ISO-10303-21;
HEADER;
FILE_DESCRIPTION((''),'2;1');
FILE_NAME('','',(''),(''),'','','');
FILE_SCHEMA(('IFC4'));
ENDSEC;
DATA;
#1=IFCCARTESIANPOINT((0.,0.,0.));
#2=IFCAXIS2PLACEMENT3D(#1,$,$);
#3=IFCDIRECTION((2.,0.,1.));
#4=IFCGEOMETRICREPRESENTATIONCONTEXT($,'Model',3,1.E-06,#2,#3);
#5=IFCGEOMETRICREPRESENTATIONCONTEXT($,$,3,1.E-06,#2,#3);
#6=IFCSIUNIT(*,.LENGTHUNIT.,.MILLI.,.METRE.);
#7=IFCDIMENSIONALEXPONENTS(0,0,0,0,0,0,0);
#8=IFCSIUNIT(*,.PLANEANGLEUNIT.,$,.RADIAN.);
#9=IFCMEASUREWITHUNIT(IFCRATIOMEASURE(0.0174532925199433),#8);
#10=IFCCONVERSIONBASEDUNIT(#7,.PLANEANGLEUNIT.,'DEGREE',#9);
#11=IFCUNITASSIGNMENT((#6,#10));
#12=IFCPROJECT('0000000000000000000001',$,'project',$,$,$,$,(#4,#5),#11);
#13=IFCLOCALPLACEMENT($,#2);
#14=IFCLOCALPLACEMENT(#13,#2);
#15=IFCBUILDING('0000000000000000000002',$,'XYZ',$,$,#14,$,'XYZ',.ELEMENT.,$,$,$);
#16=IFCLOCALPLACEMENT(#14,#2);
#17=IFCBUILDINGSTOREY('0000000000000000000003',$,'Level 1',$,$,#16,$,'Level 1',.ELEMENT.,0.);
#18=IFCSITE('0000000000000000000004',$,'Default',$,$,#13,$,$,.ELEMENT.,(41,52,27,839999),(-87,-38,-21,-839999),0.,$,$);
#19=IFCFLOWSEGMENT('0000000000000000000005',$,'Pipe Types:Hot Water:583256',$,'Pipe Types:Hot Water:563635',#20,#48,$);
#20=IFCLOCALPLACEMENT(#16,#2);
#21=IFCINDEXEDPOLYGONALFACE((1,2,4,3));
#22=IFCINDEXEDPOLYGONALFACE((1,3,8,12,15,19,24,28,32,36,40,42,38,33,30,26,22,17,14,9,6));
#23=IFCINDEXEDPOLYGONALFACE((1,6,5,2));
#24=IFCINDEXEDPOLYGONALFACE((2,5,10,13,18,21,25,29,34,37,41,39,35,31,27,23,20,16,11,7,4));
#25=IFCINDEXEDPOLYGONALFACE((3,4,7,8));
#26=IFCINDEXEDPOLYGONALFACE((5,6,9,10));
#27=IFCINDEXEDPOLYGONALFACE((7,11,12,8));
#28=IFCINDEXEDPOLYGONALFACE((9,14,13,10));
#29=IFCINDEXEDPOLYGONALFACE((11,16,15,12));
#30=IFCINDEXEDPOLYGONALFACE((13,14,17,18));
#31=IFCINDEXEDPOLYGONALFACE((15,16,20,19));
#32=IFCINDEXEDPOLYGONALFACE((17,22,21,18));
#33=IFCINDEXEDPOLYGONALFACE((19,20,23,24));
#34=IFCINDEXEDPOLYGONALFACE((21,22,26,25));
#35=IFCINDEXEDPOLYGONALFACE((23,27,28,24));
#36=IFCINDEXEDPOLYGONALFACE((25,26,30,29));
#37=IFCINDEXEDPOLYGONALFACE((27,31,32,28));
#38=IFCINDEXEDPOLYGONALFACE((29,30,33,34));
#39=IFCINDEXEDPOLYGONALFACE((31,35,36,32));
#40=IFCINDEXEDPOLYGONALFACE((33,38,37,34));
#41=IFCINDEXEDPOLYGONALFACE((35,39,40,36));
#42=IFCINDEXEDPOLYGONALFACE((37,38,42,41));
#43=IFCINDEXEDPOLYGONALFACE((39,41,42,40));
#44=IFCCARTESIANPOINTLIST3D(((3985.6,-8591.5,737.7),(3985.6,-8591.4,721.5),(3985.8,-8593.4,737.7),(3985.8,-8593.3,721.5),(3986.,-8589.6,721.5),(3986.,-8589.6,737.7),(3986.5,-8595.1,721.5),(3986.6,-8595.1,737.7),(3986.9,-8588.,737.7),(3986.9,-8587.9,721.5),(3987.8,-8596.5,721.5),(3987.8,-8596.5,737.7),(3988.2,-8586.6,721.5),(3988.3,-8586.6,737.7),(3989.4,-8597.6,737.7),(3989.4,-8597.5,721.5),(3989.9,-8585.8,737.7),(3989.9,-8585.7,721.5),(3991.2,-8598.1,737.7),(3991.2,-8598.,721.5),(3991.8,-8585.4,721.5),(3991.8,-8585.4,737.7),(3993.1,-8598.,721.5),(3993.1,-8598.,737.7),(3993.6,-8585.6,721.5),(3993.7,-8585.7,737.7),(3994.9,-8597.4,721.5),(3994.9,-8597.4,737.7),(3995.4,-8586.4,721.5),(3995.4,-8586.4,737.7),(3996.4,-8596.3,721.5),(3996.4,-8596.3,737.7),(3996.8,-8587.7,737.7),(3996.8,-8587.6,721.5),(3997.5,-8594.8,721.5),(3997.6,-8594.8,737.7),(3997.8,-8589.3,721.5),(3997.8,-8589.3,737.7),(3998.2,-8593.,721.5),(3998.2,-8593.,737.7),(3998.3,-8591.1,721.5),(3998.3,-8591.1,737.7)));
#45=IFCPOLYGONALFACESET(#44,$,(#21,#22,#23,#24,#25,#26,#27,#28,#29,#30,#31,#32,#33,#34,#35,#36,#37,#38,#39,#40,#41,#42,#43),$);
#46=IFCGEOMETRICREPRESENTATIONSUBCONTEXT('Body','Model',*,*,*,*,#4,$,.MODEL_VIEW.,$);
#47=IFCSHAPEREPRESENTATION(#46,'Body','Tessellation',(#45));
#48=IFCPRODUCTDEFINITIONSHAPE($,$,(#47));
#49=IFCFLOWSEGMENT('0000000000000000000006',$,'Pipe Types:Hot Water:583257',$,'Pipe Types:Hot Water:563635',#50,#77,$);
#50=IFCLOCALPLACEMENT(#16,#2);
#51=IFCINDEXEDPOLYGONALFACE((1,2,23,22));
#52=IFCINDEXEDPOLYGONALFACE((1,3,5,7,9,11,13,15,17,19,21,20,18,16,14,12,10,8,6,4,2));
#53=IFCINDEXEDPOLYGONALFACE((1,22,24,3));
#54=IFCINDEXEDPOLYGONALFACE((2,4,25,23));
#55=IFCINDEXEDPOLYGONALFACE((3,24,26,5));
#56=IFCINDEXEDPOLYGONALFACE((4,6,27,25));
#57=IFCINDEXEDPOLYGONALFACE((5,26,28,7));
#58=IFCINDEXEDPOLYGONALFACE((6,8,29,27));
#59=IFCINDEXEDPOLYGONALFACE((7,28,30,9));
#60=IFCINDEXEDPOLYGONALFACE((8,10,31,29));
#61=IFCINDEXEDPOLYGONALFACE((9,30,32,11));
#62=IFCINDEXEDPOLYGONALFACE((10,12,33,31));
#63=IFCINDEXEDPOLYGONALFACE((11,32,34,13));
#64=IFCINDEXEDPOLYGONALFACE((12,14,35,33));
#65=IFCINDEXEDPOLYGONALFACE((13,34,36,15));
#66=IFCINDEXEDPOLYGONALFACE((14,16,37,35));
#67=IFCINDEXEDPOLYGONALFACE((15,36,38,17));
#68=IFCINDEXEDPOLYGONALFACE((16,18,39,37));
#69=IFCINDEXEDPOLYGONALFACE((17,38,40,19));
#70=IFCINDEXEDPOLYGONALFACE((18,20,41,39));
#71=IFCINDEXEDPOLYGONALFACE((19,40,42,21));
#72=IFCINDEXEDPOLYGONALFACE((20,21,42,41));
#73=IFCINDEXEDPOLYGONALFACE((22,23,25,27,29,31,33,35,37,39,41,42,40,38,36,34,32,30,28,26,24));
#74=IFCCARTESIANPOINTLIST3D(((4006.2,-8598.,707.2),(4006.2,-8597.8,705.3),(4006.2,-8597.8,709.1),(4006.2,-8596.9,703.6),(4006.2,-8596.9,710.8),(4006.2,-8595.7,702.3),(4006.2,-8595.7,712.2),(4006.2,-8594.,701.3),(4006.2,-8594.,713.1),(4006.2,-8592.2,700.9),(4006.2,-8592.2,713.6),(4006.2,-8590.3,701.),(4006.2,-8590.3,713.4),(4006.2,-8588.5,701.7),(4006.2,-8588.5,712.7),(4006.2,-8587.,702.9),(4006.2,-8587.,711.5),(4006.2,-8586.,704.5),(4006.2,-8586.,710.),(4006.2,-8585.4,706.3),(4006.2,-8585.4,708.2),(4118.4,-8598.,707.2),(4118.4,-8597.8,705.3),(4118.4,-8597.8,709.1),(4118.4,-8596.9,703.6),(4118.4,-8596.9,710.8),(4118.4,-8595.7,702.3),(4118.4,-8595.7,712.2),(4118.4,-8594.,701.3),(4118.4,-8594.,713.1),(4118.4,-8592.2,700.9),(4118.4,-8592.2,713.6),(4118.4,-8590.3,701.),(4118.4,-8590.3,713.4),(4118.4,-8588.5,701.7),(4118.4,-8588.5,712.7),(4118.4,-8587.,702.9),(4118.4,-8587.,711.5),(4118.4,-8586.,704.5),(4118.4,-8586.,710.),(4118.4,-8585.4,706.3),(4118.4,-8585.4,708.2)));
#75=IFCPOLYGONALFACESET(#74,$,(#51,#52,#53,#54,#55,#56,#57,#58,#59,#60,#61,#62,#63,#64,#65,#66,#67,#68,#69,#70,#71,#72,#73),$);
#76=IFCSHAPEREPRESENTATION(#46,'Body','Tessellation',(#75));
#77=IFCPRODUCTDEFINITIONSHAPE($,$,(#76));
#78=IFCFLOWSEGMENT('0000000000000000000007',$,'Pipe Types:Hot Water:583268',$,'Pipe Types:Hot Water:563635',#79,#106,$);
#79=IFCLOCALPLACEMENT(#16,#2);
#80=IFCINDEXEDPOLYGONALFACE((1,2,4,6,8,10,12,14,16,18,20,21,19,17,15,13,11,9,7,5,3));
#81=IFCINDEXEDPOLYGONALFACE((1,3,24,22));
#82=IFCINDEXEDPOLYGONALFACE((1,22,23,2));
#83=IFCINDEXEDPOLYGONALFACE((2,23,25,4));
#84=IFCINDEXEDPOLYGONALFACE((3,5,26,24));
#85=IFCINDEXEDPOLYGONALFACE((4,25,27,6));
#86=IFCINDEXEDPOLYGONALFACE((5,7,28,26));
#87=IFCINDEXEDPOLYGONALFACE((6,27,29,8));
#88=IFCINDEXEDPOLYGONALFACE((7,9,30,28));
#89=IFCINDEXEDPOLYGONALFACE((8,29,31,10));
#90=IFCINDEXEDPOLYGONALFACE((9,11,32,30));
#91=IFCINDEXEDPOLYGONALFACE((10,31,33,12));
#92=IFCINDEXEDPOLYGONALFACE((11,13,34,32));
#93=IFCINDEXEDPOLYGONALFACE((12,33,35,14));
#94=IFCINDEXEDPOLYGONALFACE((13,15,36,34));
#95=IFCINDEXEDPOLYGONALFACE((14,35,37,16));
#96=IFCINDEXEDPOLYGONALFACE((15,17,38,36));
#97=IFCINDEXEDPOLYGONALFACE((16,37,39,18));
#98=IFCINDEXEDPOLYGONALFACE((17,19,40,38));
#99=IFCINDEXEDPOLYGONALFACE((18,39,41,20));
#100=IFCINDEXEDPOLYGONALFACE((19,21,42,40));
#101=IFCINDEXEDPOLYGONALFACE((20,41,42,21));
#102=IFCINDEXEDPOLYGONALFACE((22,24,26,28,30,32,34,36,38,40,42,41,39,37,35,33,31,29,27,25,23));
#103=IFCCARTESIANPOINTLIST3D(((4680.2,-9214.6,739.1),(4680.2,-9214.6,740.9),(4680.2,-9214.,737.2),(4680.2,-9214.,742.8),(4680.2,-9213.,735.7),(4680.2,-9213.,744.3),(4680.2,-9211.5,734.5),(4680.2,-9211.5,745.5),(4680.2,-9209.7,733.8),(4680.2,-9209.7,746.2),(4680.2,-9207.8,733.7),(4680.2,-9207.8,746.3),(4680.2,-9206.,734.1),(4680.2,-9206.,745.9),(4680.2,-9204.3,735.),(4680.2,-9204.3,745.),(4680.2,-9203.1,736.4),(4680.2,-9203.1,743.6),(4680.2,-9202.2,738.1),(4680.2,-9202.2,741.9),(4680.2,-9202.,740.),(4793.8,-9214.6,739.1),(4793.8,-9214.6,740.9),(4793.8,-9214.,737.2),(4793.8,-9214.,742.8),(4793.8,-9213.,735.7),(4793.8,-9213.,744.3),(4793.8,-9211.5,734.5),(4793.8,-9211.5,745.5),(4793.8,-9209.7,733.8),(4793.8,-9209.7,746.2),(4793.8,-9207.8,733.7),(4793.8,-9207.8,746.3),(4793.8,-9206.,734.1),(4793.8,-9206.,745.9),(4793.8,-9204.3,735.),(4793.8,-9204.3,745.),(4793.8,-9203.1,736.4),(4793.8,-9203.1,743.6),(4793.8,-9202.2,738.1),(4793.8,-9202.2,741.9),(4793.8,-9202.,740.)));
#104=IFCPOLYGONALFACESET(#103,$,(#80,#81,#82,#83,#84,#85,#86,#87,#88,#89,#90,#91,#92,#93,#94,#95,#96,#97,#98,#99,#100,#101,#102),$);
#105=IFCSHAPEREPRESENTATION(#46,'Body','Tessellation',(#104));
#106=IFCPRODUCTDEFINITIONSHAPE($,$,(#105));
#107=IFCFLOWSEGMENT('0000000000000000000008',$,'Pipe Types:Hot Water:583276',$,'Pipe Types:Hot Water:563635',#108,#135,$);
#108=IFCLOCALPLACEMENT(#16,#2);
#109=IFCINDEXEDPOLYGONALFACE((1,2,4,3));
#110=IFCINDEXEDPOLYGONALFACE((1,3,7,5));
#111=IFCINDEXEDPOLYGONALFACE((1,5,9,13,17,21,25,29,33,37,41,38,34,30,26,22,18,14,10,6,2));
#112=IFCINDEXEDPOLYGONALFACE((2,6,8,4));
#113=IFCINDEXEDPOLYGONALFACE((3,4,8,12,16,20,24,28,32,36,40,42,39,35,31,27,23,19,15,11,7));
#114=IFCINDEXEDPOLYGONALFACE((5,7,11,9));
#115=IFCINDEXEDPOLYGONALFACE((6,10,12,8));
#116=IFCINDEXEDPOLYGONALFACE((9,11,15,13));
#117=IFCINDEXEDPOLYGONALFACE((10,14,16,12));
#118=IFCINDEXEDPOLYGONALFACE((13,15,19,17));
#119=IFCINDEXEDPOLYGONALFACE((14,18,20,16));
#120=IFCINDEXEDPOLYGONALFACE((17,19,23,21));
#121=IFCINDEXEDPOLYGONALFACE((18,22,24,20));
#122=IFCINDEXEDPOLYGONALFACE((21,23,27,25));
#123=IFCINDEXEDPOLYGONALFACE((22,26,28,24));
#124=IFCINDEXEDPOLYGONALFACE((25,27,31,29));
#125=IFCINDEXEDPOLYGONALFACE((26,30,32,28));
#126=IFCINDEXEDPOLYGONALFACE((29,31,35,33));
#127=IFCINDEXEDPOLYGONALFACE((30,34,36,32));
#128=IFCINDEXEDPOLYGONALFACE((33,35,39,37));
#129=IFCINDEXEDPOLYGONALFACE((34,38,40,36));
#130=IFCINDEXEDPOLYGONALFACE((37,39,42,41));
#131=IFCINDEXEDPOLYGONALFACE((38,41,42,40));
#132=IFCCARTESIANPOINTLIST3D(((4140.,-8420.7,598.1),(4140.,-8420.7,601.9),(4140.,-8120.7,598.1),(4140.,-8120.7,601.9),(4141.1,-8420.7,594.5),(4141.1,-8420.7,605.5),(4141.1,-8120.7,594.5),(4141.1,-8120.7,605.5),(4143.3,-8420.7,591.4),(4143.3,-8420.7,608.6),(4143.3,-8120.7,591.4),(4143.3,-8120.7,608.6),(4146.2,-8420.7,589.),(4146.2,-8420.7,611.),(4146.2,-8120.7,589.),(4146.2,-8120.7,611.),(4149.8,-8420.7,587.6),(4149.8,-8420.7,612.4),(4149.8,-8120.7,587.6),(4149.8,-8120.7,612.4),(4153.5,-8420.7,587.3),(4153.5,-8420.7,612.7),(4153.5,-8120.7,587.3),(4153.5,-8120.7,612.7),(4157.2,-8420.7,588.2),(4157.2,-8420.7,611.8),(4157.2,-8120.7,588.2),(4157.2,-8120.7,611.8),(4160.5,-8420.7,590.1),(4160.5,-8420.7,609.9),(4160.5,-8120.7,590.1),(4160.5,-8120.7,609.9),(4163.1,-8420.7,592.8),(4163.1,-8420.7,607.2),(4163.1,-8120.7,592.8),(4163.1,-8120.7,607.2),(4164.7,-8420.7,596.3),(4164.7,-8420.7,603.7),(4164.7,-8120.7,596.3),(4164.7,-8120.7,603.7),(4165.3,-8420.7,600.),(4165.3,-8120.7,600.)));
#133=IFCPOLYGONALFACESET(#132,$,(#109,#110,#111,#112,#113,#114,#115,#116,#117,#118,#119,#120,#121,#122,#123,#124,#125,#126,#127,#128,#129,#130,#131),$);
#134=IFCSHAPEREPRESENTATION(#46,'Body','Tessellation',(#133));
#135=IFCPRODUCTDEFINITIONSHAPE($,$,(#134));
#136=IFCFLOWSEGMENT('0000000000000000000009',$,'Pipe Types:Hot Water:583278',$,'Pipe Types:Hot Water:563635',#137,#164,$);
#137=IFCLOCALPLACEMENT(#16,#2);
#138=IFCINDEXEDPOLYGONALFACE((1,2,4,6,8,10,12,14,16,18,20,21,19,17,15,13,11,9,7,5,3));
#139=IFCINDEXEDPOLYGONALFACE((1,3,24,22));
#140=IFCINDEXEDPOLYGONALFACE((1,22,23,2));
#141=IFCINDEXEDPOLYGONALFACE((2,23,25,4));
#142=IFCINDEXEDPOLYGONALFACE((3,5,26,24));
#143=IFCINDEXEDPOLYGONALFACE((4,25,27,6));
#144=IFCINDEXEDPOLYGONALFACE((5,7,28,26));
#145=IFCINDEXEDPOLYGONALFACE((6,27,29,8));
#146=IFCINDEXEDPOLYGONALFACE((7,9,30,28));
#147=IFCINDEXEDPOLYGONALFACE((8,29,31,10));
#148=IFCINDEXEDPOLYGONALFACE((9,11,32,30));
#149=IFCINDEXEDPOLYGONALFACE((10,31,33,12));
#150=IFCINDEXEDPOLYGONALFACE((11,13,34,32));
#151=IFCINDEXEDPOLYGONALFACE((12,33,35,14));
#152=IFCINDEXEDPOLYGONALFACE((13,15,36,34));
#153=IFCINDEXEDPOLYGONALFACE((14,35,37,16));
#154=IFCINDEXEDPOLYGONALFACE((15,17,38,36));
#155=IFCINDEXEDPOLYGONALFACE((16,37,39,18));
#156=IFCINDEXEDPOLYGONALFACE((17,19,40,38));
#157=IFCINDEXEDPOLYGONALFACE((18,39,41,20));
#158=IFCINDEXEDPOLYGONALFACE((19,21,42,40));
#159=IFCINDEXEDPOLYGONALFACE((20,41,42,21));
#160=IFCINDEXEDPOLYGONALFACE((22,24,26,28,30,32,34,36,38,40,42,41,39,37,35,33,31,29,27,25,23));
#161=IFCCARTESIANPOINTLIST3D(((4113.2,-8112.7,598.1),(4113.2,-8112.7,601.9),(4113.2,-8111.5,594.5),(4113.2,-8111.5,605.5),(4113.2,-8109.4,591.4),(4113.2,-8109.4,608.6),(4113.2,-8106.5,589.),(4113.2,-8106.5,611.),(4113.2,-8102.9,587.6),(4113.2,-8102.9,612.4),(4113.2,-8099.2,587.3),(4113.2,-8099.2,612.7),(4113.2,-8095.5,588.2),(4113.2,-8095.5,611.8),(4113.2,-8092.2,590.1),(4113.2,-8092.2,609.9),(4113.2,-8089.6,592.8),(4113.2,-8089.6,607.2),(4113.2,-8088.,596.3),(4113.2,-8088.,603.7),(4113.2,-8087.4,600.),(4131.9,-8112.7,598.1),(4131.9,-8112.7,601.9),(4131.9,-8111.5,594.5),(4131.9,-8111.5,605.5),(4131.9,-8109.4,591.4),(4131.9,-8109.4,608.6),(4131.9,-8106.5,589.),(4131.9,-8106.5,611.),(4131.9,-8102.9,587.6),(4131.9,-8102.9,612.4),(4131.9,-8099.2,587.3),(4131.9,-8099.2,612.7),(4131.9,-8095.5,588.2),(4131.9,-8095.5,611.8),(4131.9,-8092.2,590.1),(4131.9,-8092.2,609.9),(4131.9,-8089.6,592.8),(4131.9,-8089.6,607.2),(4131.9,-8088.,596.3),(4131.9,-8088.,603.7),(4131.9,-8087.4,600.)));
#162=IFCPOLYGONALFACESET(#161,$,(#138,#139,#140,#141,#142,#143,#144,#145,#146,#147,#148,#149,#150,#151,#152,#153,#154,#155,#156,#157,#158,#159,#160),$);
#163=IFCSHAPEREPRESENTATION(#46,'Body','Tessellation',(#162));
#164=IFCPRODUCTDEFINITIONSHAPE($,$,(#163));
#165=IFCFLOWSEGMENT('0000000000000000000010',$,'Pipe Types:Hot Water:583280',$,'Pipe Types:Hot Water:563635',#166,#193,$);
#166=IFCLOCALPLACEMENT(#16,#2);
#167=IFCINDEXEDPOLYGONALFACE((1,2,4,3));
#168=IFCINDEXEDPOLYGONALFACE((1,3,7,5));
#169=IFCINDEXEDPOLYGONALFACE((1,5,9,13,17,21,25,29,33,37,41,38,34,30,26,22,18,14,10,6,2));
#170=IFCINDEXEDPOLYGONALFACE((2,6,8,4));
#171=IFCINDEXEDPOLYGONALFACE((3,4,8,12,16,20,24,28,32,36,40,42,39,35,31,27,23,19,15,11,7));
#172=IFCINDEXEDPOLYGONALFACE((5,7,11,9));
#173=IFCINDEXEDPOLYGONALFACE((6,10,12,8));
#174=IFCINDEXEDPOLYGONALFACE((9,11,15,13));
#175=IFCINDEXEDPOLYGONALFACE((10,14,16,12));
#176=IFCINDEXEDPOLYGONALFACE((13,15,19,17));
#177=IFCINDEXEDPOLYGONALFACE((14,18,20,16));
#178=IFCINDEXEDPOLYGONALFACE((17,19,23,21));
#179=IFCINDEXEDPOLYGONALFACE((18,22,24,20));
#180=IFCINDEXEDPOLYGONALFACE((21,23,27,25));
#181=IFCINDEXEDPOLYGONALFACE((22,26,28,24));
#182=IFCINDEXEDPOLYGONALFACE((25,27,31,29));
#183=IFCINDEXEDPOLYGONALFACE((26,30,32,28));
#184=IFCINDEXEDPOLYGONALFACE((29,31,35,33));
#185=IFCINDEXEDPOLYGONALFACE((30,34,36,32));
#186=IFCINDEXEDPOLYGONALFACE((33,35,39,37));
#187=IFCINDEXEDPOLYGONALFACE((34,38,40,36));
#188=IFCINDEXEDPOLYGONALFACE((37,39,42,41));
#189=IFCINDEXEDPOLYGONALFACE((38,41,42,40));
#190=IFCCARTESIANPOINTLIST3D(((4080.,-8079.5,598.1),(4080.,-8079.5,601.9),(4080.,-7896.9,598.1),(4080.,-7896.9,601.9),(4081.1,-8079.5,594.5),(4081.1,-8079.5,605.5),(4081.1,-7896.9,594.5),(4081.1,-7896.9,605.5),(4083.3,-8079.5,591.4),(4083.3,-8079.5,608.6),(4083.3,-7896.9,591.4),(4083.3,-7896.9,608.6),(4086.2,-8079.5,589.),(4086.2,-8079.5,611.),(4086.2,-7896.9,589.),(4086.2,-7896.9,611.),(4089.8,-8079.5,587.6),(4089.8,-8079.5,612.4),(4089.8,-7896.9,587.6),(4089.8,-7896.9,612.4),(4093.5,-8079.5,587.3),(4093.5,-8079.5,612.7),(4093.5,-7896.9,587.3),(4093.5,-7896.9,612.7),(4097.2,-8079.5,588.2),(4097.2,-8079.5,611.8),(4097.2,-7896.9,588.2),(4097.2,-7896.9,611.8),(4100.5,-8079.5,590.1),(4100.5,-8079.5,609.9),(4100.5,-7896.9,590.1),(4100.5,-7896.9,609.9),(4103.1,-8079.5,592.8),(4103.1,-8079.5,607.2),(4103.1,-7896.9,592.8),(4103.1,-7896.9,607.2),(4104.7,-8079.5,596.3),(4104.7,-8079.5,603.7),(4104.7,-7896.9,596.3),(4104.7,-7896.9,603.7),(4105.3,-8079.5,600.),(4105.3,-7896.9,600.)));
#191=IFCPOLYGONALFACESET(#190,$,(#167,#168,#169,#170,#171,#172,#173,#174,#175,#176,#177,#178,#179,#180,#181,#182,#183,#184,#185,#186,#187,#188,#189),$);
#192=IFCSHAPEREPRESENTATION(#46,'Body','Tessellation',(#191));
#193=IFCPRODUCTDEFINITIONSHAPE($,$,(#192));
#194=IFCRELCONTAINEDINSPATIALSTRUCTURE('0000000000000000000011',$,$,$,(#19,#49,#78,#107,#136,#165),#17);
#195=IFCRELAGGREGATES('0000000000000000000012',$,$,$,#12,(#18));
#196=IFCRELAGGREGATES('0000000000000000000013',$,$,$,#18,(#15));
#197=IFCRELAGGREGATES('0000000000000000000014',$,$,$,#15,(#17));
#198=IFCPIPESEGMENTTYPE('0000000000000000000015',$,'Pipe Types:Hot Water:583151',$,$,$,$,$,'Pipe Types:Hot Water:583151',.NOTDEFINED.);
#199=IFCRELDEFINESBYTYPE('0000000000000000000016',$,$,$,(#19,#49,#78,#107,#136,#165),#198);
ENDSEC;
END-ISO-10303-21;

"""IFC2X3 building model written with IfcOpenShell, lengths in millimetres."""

from ifc_helpers import new_model, entity, si_unit, converted_unit, direction, frame, frame_2d, origin, origin_2d_with_axis, place, context, subcontext, project, spatial, circle, extrude, type_object, element, save


model = new_model("IFC2X3")

# Units and contexts
model_context = context("Model", 3, precision=1e-06, world=origin(), true_north=direction((2.0, 0.0, 1.0)))
context_of_model = context(None, 3, precision=1e-06, world=origin(), true_north=direction((2.0, 0.0, 1.0)))
body_context = subcontext(model_context, "Body", "Model", "MODEL_VIEW")
ifc_project = project(units=[si_unit("LENGTHUNIT", "METRE", prefix="MILLI"), converted_unit("PLANEANGLEUNIT", "DEGREE", entity("IfcRatioMeasure", 0.0174532925199433), si_unit("PLANEANGLEUNIT", "RADIAN"), dimensions=[0, 0, 0, 0, 0, 0, 0])], contexts=[model_context, context_of_model])

# Site, building, storey
site_placement = place(None, origin())
site = spatial("IfcSite", under=ifc_project, at=site_placement, Name="Default", CompositionType="ELEMENT", RefLatitude=(41, 52, 27, 839999), RefLongitude=(-87, -38, -21, -839999), RefElevation=0.0)
building_placement = place(site_placement, origin())
building = spatial("IfcBuilding", under=site, at=building_placement, Name="XYZ", LongName="XYZ", CompositionType="ELEMENT")
storey_placement = place(building_placement, origin())
storey = spatial("IfcBuildingStorey", under=building, at=storey_placement, Name="Level 1", LongName="Level 1", CompositionType="ELEMENT", Elevation=0.0)

# Flow segments
pipe_segment_type_1 = type_object("IfcPipeSegmentType", Name="Pipe Types:Hot Water:583151", ElementType="Pipe Types:Hot Water:583151", PredefinedType="NOTDEFINED")
flow_segment_1_placement = place(storey_placement, origin())
element("IfcFlowSegment", 1, at=flow_segment_1_placement, inside=storey, type_object=pipe_segment_type_1, Name="Pipe Types:Hot Water:583256", ObjectType="Pipe Types:Hot Water:563635", context=body_context, shape_type="SweptSolid", body=[
    extrude(circle(Radius=6.3, at=frame_2d((0.0, 0.0), x_axis=(1.0, 0.0))), frame((3991.9, -8591.7, 721.5), z_axis=(0.002159, -0.00189, 0.999996), x_axis=(-0.658653, -0.752447, 0.0)), (0.0, 0.0, 1.0), 16.2),
])
flow_segment_2_placement = place(storey_placement, origin())
element("IfcFlowSegment", 2, at=flow_segment_2_placement, inside=storey, type_object=pipe_segment_type_1, Name="Pipe Types:Hot Water:583257", ObjectType="Pipe Types:Hot Water:563635", context=body_context, shape_type="SweptSolid", body=[
    extrude(circle(Radius=6.3, at=origin_2d_with_axis()), frame((4006.2, -8591.7, 707.2), z_axis=(1.0, 0.0, 0.0), x_axis=(0.0, -1.0, 0.0)), (0.0, 0.0, 1.0), 112.2),
])
flow_segment_3_placement = place(storey_placement, origin())
element("IfcFlowSegment", 3, at=flow_segment_3_placement, inside=storey, type_object=pipe_segment_type_1, Name="Pipe Types:Hot Water:583268", ObjectType="Pipe Types:Hot Water:563635", context=body_context, shape_type="SweptSolid", body=[
    extrude(circle(Radius=6.3, at=origin_2d_with_axis()), frame((4680.2, -9208.3, 740.0), z_axis=(1.0, 0.0, 0.0), x_axis=(0.0, 1.0, 0.0)), (0.0, 0.0, 1.0), 113.6),
])
flow_segment_4_placement = place(storey_placement, origin())
element("IfcFlowSegment", 4, at=flow_segment_4_placement, inside=storey, type_object=pipe_segment_type_1, Name="Pipe Types:Hot Water:583276", ObjectType="Pipe Types:Hot Water:563635", context=body_context, shape_type="SweptSolid", body=[
    extrude(circle(Radius=12.7, at=origin_2d_with_axis()), frame((4152.6, -8420.7, 600.0), z_axis=(0.0, 1.0, 0.0), x_axis=(1.0, 0.0, 0.0)), (0.0, 0.0, 1.0), 299.9),
])
flow_segment_5_placement = place(storey_placement, origin())
element("IfcFlowSegment", 5, at=flow_segment_5_placement, inside=storey, type_object=pipe_segment_type_1, Name="Pipe Types:Hot Water:583278", ObjectType="Pipe Types:Hot Water:563635", context=body_context, shape_type="SweptSolid", body=[
    extrude(circle(Radius=12.7, at=frame_2d((0.0, 0.0), x_axis=(1.0, 0.0))), frame((4113.2, -8100.1, 600.0), z_axis=(1.0, 0.0, 0.0), x_axis=(0.0, 1.0, 0.0)), (0.0, 0.0, 1.0), 18.7),
])
flow_segment_6_placement = place(storey_placement, origin())
element("IfcFlowSegment", 6, at=flow_segment_6_placement, inside=storey, type_object=pipe_segment_type_1, Name="Pipe Types:Hot Water:583280", ObjectType="Pipe Types:Hot Water:563635", context=body_context, shape_type="SweptSolid", body=[
    extrude(circle(Radius=12.7, at=origin_2d_with_axis()), frame((4092.6, -8079.5, 600.0), z_axis=(0.0, 1.0, 0.0), x_axis=(1.0, 0.0, 0.0)), (0.0, 0.0, 1.0), 182.5),
])

save(model, "model.ifc")
